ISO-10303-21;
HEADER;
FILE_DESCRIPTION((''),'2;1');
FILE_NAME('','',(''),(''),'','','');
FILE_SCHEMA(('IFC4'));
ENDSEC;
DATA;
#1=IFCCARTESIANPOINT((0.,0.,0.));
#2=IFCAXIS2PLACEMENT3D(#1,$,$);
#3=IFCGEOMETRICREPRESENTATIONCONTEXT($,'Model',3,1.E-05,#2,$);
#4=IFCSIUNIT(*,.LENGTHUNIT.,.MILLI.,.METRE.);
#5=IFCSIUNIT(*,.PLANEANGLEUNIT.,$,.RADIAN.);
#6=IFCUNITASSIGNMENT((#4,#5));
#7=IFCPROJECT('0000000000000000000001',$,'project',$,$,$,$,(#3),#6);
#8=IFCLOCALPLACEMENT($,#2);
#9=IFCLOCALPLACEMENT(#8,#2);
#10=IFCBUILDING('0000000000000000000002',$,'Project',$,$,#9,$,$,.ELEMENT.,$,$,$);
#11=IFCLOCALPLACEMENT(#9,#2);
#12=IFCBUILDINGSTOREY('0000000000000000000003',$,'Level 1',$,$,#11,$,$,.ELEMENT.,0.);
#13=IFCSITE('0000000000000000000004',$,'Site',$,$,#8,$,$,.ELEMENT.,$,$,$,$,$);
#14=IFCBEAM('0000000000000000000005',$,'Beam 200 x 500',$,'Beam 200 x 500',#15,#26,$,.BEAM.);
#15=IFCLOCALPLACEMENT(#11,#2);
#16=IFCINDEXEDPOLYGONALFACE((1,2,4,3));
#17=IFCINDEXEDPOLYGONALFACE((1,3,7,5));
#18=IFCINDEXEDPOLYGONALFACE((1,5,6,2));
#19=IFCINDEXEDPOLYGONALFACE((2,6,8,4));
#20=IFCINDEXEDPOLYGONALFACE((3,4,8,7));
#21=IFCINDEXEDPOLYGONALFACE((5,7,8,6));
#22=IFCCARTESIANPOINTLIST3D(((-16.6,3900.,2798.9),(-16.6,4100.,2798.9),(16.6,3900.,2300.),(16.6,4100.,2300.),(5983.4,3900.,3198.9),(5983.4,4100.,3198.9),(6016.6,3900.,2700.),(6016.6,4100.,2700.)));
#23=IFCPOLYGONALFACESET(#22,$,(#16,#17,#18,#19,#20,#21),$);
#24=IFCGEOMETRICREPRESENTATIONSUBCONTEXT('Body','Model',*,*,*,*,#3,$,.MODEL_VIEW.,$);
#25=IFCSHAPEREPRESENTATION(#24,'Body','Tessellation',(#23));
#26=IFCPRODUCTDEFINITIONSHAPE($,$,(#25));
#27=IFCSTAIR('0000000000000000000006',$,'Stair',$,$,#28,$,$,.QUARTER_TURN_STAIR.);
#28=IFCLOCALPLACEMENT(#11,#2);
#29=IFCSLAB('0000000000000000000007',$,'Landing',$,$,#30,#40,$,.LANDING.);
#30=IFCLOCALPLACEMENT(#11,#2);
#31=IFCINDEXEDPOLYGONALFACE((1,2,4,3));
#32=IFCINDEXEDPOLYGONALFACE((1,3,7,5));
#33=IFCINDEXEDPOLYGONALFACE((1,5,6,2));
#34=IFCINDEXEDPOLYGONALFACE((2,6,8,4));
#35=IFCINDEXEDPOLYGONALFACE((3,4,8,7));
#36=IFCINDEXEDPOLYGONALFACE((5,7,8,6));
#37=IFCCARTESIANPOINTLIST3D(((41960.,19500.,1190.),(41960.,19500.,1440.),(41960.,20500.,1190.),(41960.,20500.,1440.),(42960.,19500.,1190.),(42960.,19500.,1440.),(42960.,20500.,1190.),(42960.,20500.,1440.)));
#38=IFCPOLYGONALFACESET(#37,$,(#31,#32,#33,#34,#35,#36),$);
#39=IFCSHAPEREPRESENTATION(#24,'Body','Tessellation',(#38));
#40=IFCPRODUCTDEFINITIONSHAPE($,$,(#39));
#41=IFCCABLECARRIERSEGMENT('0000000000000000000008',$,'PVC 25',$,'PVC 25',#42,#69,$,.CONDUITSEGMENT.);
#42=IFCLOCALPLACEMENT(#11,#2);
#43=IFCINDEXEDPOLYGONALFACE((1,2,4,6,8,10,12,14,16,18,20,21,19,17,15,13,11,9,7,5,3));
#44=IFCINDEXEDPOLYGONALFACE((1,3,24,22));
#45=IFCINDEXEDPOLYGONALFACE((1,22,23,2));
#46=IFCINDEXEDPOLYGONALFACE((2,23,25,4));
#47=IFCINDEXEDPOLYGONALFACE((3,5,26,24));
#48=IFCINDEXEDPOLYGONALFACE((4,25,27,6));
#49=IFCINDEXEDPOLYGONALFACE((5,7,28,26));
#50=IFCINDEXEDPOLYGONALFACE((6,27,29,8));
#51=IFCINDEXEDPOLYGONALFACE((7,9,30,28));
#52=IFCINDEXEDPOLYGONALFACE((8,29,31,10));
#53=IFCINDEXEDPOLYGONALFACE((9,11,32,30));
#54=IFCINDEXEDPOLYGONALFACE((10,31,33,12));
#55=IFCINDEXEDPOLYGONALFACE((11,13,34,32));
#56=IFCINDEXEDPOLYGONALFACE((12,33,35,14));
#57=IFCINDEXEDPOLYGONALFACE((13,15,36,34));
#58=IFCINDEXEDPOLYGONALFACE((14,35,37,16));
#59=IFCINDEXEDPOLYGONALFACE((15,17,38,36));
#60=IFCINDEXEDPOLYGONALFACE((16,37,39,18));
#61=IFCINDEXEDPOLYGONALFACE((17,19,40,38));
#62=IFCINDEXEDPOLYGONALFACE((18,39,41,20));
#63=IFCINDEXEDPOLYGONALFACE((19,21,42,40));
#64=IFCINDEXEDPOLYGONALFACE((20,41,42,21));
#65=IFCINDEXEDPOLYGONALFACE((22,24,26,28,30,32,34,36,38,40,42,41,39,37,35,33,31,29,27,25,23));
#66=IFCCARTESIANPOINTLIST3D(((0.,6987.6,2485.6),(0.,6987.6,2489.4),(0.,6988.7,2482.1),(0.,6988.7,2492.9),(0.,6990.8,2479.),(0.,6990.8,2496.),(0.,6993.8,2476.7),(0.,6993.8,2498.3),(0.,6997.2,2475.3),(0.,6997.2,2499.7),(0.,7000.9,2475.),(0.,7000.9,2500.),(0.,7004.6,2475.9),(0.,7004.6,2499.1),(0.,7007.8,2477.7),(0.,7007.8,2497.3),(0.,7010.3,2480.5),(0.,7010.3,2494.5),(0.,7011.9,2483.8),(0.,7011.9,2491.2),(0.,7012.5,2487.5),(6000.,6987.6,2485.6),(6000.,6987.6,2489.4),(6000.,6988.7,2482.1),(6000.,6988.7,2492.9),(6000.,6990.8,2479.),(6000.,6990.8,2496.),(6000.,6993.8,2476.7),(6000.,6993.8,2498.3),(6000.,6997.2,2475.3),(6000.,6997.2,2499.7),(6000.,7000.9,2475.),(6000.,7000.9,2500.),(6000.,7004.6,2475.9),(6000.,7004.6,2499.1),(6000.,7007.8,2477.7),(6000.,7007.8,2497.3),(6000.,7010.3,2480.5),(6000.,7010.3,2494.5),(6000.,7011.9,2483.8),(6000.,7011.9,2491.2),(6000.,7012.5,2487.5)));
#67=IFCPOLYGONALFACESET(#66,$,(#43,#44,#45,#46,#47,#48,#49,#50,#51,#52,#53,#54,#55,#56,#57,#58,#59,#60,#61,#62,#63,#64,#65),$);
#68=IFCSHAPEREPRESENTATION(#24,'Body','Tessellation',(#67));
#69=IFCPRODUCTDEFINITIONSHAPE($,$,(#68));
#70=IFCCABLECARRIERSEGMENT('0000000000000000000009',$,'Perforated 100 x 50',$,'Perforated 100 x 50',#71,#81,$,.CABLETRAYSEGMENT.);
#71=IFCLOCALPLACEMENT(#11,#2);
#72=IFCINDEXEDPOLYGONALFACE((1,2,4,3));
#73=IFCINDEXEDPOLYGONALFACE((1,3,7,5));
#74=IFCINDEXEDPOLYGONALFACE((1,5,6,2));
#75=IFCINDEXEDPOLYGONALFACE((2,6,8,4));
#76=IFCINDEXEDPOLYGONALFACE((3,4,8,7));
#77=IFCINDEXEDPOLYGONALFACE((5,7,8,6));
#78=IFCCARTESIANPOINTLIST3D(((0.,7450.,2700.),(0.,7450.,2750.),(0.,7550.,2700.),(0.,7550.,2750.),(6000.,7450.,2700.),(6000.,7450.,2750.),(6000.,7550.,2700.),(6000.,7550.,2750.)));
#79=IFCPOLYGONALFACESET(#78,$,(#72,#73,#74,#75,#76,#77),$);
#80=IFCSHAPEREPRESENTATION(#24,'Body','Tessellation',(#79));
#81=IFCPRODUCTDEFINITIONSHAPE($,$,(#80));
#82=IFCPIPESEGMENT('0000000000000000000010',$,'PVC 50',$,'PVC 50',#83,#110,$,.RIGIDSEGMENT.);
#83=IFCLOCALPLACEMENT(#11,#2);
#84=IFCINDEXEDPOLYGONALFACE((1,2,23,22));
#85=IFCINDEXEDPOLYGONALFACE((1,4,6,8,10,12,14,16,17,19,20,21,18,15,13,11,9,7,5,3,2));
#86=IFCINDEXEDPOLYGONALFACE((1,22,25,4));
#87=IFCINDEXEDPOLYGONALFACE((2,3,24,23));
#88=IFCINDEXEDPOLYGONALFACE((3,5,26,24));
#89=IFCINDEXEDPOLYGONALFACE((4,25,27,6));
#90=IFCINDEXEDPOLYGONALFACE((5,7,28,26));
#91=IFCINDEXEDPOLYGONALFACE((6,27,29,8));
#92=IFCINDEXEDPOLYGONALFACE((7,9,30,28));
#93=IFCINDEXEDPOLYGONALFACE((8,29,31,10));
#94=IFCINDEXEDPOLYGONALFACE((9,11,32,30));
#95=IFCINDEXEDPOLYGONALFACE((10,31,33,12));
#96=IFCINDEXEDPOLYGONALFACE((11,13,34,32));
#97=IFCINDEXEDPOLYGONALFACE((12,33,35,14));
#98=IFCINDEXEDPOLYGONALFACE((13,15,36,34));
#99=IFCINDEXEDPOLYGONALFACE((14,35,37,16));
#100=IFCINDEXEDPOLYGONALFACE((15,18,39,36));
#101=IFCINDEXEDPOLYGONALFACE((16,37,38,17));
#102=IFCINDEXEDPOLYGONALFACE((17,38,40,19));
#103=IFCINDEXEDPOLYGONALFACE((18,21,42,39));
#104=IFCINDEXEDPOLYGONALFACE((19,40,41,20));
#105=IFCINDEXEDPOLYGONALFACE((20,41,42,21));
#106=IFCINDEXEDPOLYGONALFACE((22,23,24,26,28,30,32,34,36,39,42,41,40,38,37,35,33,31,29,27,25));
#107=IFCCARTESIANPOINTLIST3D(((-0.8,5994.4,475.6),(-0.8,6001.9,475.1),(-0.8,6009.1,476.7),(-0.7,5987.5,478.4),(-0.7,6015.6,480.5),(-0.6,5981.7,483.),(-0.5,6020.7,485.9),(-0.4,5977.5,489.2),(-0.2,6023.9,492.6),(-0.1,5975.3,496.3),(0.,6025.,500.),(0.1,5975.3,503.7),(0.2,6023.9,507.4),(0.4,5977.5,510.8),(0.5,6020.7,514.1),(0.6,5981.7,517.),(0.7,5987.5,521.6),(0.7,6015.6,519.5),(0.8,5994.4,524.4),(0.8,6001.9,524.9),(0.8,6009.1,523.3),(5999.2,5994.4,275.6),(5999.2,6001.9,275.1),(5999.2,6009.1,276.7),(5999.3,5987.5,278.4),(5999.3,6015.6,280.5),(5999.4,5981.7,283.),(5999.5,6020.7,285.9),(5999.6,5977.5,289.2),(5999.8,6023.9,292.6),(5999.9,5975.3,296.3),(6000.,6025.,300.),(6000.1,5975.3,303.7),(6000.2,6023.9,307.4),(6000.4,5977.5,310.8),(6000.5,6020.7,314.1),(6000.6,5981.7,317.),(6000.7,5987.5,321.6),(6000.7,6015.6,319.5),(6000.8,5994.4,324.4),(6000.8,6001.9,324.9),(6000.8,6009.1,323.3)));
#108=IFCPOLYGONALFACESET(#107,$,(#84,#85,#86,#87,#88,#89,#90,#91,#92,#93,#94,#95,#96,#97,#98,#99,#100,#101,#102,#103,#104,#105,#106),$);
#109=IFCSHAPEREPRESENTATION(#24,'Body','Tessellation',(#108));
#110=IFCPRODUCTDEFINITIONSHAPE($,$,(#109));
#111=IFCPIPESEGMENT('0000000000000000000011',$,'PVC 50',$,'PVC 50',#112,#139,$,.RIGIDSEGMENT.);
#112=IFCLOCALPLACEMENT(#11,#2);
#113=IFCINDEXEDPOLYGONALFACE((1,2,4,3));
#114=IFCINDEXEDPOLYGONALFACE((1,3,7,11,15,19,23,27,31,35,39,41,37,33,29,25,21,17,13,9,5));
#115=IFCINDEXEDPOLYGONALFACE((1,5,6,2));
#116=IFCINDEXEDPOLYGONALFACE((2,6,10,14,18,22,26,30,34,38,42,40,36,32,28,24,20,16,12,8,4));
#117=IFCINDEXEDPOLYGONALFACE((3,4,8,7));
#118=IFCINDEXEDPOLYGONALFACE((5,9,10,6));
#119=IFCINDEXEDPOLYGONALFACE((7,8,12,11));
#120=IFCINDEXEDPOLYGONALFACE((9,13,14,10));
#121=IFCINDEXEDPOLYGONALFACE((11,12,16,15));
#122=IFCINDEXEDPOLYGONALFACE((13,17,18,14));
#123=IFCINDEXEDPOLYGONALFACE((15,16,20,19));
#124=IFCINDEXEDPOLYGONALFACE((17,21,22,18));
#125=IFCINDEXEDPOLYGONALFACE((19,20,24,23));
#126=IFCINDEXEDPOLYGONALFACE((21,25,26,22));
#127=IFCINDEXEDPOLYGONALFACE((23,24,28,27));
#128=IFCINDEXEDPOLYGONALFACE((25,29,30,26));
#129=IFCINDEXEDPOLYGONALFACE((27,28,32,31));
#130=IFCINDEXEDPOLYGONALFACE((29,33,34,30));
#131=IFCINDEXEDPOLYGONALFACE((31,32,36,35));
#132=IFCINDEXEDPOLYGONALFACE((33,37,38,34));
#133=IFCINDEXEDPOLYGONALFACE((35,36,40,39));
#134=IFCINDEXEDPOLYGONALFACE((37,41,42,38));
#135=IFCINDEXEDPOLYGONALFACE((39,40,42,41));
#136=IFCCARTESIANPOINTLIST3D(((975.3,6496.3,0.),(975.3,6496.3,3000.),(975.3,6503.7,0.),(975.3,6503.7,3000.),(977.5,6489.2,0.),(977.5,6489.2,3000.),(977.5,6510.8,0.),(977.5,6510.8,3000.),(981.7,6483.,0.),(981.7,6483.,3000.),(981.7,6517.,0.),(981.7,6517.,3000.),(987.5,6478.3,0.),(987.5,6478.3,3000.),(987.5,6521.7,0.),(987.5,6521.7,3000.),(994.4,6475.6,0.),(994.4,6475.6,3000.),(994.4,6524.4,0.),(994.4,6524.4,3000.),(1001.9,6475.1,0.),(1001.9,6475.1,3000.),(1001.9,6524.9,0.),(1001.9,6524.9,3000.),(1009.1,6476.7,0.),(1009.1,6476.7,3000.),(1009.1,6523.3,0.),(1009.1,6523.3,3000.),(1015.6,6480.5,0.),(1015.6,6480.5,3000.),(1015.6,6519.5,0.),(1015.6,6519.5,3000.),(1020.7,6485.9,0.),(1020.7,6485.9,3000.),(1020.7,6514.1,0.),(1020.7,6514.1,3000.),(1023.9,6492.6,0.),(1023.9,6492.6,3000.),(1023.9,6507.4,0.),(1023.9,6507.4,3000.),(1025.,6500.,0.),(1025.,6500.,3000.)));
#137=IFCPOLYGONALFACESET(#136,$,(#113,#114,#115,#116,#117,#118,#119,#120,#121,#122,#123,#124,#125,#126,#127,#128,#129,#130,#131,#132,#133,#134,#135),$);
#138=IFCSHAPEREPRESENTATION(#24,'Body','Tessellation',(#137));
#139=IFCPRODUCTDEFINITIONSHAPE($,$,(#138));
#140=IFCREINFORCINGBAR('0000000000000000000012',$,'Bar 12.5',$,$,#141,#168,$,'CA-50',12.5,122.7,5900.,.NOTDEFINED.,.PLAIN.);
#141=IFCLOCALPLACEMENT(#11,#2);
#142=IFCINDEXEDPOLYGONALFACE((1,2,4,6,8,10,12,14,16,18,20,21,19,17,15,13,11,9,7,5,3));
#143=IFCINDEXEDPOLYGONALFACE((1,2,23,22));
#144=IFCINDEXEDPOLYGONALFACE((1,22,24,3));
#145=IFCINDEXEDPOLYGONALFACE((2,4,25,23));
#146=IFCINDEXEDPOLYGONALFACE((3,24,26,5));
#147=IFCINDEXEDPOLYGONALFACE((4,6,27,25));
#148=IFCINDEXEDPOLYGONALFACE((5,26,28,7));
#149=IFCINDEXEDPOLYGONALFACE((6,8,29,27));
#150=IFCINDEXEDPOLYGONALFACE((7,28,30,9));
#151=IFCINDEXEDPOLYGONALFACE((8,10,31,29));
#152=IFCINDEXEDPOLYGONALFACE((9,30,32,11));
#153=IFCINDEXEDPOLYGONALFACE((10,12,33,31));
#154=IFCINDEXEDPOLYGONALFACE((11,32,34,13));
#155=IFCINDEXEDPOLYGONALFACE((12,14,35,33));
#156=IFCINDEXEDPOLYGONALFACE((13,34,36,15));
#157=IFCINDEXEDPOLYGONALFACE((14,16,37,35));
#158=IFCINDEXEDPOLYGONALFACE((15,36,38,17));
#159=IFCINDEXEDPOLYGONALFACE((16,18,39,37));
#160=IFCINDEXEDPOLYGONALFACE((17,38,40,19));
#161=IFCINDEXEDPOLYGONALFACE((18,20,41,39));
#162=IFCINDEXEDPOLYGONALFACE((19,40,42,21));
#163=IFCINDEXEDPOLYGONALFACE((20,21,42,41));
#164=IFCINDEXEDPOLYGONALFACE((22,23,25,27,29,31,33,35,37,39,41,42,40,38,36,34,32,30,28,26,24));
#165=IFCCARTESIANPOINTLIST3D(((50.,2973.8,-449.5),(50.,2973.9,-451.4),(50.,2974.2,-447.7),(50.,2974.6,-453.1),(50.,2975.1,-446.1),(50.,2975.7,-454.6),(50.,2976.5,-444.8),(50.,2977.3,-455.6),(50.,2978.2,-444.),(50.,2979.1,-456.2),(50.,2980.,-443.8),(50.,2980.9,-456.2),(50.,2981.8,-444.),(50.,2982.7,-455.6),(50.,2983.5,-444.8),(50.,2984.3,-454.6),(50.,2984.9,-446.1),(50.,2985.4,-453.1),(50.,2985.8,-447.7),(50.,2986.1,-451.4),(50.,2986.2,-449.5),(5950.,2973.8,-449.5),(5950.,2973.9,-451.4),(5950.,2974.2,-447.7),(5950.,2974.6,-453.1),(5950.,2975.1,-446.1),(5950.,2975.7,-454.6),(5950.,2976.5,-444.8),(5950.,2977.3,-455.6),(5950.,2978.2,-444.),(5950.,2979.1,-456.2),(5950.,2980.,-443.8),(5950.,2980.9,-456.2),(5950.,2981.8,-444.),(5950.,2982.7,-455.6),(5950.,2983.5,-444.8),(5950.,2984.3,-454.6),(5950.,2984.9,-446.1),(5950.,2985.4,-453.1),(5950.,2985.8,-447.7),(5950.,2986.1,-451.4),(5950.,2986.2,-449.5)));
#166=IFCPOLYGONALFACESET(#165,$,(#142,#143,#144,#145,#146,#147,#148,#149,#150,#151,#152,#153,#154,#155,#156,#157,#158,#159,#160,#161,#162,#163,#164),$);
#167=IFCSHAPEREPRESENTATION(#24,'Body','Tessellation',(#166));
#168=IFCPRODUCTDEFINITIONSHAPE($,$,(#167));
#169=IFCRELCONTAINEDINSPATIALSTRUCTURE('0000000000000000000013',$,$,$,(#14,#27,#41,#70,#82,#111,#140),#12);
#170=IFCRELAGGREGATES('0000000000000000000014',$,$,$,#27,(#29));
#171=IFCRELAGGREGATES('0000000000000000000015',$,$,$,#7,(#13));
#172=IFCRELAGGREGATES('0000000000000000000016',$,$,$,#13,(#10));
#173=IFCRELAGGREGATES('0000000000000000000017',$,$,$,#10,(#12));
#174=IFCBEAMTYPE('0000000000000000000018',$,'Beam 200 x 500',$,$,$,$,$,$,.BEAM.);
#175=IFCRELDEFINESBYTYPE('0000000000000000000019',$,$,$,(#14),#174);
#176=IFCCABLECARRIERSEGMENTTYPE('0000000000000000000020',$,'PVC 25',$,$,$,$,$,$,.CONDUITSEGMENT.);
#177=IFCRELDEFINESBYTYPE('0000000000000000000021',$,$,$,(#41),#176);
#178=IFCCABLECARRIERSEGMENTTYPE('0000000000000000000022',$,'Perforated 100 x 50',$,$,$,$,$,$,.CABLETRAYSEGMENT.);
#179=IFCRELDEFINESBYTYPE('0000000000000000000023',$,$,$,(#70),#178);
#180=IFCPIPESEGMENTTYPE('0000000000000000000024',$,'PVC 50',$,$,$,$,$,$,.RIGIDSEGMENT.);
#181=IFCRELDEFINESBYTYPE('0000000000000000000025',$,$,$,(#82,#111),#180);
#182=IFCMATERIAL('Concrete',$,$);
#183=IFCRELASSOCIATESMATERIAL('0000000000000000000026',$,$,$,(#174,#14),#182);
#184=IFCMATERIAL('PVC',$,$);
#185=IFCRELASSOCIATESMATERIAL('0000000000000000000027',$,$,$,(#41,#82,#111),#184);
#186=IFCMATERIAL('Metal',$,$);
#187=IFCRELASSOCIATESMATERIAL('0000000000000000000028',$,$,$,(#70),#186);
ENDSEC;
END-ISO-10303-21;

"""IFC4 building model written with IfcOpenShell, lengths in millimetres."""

from ifc_helpers import new_model, entity, si_unit, frame, origin, origin_with_axes, origin_2d, place, context, subcontext, project, spatial, polyline, rectangle, circle, outline, extrude, material, material_profile, profile_set, profile_usage, type_object, element, aggregate, save


model = new_model("IFC4")

# Units and contexts
model_context = context("Model", 3, precision=1e-05, world=origin())
body_context = subcontext(model_context, "Body", "Model", "MODEL_VIEW")
ifc_project = project(units=[si_unit("LENGTHUNIT", "METRE", prefix="MILLI"), si_unit("PLANEANGLEUNIT", "RADIAN")], contexts=[model_context])

# Site, building, storey
site_placement = place(None, origin())
site = spatial("IfcSite", under=ifc_project, at=site_placement, Name="Site", CompositionType="ELEMENT")
building_placement = place(site_placement, origin())
building = spatial("IfcBuilding", under=site, at=building_placement, Name="Project", CompositionType="ELEMENT")
storey_placement = place(building_placement, origin())
storey = spatial("IfcBuildingStorey", under=building, at=storey_placement, Name="Level 1", CompositionType="ELEMENT", Elevation=0.0)

# Beam
ifc_material_1 = material(Name="Concrete")
ifc_material_profile = material_profile(ifc_material_1, rectangle(XDim=200.0, YDim=500.0, at=origin_2d()), Name="Beam 200 x 500")
ifc_profile_set = profile_set([ifc_material_profile], Name="Beam 200 x 500")
ifc_profile_usage = profile_usage(ifc_profile_set, cardinal=8)
beam_type = type_object("IfcBeamType", Name="Beam 200 x 500", PredefinedType="BEAM", material=ifc_profile_set)
beam_placement = place(storey_placement, frame((0.0, 4000.0, 2549.4)))
element("IfcBeam", 1, at=beam_placement, inside=storey, type_object=beam_type, material=ifc_profile_usage, Name="Beam 200 x 500", ObjectType="Beam 200 x 500", PredefinedType="BEAM", context=body_context, shape_type="SweptSolid", body=[
    extrude(rectangle(XDim=200.0, YDim=500.0, at=origin_2d()), frame((0.0, 0.0, 0.0), z_axis=(0.997785, 0.0, 0.066519), x_axis=(0.0, 1.0, 0.0)), (0.0, 0.0, 1.0), 6013.3),
])

# Stair, slab
stair_placement = place(storey_placement, origin())
stair = element("IfcStair", 2, at=stair_placement, inside=storey, Name="Stair", PredefinedType="QUARTER_TURN_STAIR")
slab_placement = place(stair_placement, origin())
slab = element("IfcSlab", 3, at=slab_placement, Name="Landing", PredefinedType="LANDING", context=body_context, shape_type="SweptSolid", body=[
    extrude(outline(polyline([(41960.0, 19500.0), (42960.0, 19500.0), (42960.0, 20500.0), (41960.0, 20500.0), (41960.0, 19500.0)])), frame((0.0, 0.0, 1190.0)), (0.0, 0.0, 1.0), 250.0),
])
aggregate(stair, [slab])

# Cable carrier segments
ifc_material_2 = material(Name="PVC")
cable_carrier_segment_type_1 = type_object("IfcCableCarrierSegmentType", Name="PVC 25", PredefinedType="CONDUITSEGMENT")
cable_carrier_segment_1_placement = place(storey_placement, frame((0.0, 7000.0, 2487.5)))
element("IfcCableCarrierSegment", 4, at=cable_carrier_segment_1_placement, inside=storey, type_object=cable_carrier_segment_type_1, material=ifc_material_2, Name="PVC 25", ObjectType="PVC 25", PredefinedType="CONDUITSEGMENT", context=body_context, shape_type="SweptSolid", body=[
    extrude(circle(Radius=12.5, at=origin_2d()), frame((0.0, 0.0, 0.0), z_axis=(1.0, 0.0, 0.0), x_axis=(0.0, 1.0, 0.0)), (0.0, 0.0, 1.0), 6000.0),
])
ifc_material_3 = material(Name="Metal")
cable_carrier_segment_type_2 = type_object("IfcCableCarrierSegmentType", Name="Perforated 100 x 50", PredefinedType="CABLETRAYSEGMENT")
cable_carrier_segment_2_placement = place(storey_placement, frame((0.0, 7500.0, 2725.0)))
element("IfcCableCarrierSegment", 5, at=cable_carrier_segment_2_placement, inside=storey, type_object=cable_carrier_segment_type_2, material=ifc_material_3, Name="Perforated 100 x 50", ObjectType="Perforated 100 x 50", PredefinedType="CABLETRAYSEGMENT", context=body_context, shape_type="SweptSolid", body=[
    extrude(rectangle(XDim=100.0, YDim=50.0, at=origin_2d()), frame((0.0, 0.0, 0.0), z_axis=(1.0, 0.0, 0.0), x_axis=(0.0, 1.0, 0.0)), (0.0, 0.0, 1.0), 6000.0),
])

# Pipe segments
pipe_segment_type = type_object("IfcPipeSegmentType", Name="PVC 50", PredefinedType="RIGIDSEGMENT")
pipe_segment_1_placement = place(storey_placement, frame((0.0, 6000.0, 500.0)))
element("IfcPipeSegment", 6, at=pipe_segment_1_placement, inside=storey, type_object=pipe_segment_type, material=ifc_material_2, Name="PVC 50", ObjectType="PVC 50", PredefinedType="RIGIDSEGMENT", context=body_context, shape_type="SweptSolid", body=[
    extrude(circle(Radius=25.0, at=origin_2d()), frame((0.0, 0.0, 0.0), z_axis=(0.999445, 0.0, -0.033315), x_axis=(0.0, 1.0, 0.0)), (0.0, 0.0, 1.0), 6003.3),
])
pipe_segment_2_placement = place(storey_placement, frame((1000.0, 6500.0, 0.0)))
element("IfcPipeSegment", 7, at=pipe_segment_2_placement, inside=storey, type_object=pipe_segment_type, material=ifc_material_2, Name="PVC 50", ObjectType="PVC 50", PredefinedType="RIGIDSEGMENT", context=body_context, shape_type="SweptSolid", body=[
    extrude(circle(Radius=25.0, at=origin_2d()), origin_with_axes(), (0.0, 0.0, 1.0), 3000.0),
])

# Reinforcing bar
reinforcing_bar_1_placement = place(storey_placement, origin())
element("IfcReinforcingBar", 8, at=reinforcing_bar_1_placement, inside=storey, Name="Bar 12.5", SteelGrade="CA-50", BarLength=5900.0, BarSurface="PLAIN", CrossSectionArea=122.7, NominalDiameter=12.5, PredefinedType="NOTDEFINED", context=body_context, shape_type="AdvancedSweptSolid", body=[
    entity("IfcSweptDiskSolid", entity("IfcPolyline", [entity("IfcCartesianPoint", [50.0, 2980.0, -450.0]), entity("IfcCartesianPoint", [5950.0, 2980.0, -450.0])]), 6.2),
])

save(model, "model.ifc")
